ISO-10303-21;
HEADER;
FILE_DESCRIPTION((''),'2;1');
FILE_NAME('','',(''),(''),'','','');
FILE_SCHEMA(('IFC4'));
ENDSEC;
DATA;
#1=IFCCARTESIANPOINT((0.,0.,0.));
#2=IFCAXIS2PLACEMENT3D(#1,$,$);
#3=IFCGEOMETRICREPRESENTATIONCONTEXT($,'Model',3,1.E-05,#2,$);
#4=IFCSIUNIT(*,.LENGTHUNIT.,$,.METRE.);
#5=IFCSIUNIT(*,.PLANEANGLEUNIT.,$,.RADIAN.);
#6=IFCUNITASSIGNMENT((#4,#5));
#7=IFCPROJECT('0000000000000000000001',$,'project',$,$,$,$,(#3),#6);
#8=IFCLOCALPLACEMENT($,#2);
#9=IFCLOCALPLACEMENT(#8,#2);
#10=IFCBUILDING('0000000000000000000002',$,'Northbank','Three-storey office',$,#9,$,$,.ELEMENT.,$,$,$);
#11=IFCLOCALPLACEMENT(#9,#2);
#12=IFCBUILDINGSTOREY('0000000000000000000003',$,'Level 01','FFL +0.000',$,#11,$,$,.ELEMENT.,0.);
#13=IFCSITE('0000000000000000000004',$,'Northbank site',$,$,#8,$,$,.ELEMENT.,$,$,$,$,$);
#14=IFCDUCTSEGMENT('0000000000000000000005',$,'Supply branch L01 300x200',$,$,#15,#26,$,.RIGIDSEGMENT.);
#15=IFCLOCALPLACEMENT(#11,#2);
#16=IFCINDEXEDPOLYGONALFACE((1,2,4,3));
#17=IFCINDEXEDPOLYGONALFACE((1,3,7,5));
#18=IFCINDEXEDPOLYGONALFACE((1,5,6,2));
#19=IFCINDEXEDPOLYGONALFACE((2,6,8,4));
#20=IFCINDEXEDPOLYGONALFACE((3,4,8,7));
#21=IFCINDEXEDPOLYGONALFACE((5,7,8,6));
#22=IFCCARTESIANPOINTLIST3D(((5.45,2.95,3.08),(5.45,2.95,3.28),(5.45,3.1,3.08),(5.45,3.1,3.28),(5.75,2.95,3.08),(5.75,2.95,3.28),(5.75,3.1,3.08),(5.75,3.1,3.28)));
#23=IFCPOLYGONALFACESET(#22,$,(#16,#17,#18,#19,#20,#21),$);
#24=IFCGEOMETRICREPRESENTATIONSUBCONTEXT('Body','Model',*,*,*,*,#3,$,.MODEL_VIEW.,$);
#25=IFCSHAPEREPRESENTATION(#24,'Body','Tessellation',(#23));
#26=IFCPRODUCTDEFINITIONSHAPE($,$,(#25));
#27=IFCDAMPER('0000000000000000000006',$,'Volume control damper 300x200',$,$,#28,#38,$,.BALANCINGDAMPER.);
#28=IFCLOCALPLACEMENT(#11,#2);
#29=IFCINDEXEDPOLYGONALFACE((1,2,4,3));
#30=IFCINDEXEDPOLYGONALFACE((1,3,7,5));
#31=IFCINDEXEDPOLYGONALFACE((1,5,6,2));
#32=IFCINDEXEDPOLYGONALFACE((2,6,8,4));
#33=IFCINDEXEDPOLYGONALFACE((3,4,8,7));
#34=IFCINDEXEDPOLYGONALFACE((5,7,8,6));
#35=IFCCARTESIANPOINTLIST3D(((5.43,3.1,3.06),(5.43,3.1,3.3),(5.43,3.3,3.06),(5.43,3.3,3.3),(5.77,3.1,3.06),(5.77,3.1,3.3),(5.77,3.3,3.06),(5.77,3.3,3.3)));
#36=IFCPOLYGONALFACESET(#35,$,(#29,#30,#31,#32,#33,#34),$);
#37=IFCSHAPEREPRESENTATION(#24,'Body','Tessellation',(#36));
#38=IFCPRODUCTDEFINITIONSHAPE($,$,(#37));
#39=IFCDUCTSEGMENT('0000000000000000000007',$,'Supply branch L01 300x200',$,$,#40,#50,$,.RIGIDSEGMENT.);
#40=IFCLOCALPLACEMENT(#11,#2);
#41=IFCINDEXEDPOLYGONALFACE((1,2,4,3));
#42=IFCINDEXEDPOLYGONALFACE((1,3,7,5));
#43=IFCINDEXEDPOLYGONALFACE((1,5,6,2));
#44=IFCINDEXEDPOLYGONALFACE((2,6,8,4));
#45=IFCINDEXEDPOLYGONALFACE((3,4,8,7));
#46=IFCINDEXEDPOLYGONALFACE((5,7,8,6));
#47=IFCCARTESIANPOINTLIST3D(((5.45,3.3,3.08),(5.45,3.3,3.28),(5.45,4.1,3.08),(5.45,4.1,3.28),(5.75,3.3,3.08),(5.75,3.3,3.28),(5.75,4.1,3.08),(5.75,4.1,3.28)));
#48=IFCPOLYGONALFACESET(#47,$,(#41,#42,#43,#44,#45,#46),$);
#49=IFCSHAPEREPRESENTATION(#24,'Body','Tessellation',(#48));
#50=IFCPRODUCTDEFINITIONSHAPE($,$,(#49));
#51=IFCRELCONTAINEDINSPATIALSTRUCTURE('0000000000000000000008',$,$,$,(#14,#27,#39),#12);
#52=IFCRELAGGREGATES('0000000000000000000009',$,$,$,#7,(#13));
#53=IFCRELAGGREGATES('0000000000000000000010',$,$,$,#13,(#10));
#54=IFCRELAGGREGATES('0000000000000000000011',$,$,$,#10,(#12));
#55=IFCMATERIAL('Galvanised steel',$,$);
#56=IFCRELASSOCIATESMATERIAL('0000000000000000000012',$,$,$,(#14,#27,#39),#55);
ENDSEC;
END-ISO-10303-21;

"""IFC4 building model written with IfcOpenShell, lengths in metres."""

from ifc_helpers import new_model, si_unit, frame, origin, place, context, subcontext, project, spatial, rectangle, extrude, material, element, save


model = new_model("IFC4")

# Units and contexts
model_context = context("Model", 3, precision=1e-05, world=origin())
body_context = subcontext(model_context, "Body", "Model", "MODEL_VIEW")
ifc_project = project(units=[si_unit("LENGTHUNIT", "METRE"), si_unit("PLANEANGLEUNIT", "RADIAN")], contexts=[model_context])

# Site, building, storey
site_placement = place(None, origin())
site = spatial("IfcSite", under=ifc_project, at=site_placement, Name="Northbank site", CompositionType="ELEMENT")
building_placement = place(site_placement, origin())
building = spatial("IfcBuilding", under=site, at=building_placement, Name="Northbank", Description="Three-storey office", CompositionType="ELEMENT")
storey_placement = place(building_placement, origin())
storey = spatial("IfcBuildingStorey", under=building, at=storey_placement, Name="Level 01", Description="FFL +0.000", CompositionType="ELEMENT", Elevation=0.0)

# Shared definitions
ifc_material_1 = material(Name="Galvanised steel")

# Duct segment
duct_segment_1_placement = place(storey_placement, origin())
element("IfcDuctSegment", 1, at=duct_segment_1_placement, inside=storey, material=ifc_material_1, Name="Supply branch L01 300x200", PredefinedType="RIGIDSEGMENT", context=body_context, shape_type="SweptSolid", body=[
    extrude(rectangle(XDim=0.3, YDim=0.2), frame((5.6, 2.95, 3.18), z_axis=(0.0, 1.0, 0.0), x_axis=(-1.0, 0.0, 0.0)), (0.0, 0.0, 1.0), 0.15),
])

# Damper
damper_1_placement = place(storey_placement, origin())
element("IfcDamper", 2, at=damper_1_placement, inside=storey, material=ifc_material_1, Name="Volume control damper 300x200", PredefinedType="BALANCINGDAMPER", context=body_context, shape_type="SweptSolid", body=[
    extrude(rectangle(XDim=0.34, YDim=0.24), frame((5.6, 3.1, 3.18), z_axis=(0.0, 1.0, 0.0), x_axis=(-1.0, 0.0, 0.0)), (0.0, 0.0, 1.0), 0.2),
])

# Duct segment
duct_segment_2_placement = place(storey_placement, origin())
element("IfcDuctSegment", 3, at=duct_segment_2_placement, inside=storey, material=ifc_material_1, Name="Supply branch L01 300x200", PredefinedType="RIGIDSEGMENT", context=body_context, shape_type="SweptSolid", body=[
    extrude(rectangle(XDim=0.3, YDim=0.2), frame((5.6, 3.3, 3.18), z_axis=(0.0, 1.0, 0.0), x_axis=(-1.0, 0.0, 0.0)), (0.0, 0.0, 1.0), 0.8),
])

save(model, "model.ifc")
